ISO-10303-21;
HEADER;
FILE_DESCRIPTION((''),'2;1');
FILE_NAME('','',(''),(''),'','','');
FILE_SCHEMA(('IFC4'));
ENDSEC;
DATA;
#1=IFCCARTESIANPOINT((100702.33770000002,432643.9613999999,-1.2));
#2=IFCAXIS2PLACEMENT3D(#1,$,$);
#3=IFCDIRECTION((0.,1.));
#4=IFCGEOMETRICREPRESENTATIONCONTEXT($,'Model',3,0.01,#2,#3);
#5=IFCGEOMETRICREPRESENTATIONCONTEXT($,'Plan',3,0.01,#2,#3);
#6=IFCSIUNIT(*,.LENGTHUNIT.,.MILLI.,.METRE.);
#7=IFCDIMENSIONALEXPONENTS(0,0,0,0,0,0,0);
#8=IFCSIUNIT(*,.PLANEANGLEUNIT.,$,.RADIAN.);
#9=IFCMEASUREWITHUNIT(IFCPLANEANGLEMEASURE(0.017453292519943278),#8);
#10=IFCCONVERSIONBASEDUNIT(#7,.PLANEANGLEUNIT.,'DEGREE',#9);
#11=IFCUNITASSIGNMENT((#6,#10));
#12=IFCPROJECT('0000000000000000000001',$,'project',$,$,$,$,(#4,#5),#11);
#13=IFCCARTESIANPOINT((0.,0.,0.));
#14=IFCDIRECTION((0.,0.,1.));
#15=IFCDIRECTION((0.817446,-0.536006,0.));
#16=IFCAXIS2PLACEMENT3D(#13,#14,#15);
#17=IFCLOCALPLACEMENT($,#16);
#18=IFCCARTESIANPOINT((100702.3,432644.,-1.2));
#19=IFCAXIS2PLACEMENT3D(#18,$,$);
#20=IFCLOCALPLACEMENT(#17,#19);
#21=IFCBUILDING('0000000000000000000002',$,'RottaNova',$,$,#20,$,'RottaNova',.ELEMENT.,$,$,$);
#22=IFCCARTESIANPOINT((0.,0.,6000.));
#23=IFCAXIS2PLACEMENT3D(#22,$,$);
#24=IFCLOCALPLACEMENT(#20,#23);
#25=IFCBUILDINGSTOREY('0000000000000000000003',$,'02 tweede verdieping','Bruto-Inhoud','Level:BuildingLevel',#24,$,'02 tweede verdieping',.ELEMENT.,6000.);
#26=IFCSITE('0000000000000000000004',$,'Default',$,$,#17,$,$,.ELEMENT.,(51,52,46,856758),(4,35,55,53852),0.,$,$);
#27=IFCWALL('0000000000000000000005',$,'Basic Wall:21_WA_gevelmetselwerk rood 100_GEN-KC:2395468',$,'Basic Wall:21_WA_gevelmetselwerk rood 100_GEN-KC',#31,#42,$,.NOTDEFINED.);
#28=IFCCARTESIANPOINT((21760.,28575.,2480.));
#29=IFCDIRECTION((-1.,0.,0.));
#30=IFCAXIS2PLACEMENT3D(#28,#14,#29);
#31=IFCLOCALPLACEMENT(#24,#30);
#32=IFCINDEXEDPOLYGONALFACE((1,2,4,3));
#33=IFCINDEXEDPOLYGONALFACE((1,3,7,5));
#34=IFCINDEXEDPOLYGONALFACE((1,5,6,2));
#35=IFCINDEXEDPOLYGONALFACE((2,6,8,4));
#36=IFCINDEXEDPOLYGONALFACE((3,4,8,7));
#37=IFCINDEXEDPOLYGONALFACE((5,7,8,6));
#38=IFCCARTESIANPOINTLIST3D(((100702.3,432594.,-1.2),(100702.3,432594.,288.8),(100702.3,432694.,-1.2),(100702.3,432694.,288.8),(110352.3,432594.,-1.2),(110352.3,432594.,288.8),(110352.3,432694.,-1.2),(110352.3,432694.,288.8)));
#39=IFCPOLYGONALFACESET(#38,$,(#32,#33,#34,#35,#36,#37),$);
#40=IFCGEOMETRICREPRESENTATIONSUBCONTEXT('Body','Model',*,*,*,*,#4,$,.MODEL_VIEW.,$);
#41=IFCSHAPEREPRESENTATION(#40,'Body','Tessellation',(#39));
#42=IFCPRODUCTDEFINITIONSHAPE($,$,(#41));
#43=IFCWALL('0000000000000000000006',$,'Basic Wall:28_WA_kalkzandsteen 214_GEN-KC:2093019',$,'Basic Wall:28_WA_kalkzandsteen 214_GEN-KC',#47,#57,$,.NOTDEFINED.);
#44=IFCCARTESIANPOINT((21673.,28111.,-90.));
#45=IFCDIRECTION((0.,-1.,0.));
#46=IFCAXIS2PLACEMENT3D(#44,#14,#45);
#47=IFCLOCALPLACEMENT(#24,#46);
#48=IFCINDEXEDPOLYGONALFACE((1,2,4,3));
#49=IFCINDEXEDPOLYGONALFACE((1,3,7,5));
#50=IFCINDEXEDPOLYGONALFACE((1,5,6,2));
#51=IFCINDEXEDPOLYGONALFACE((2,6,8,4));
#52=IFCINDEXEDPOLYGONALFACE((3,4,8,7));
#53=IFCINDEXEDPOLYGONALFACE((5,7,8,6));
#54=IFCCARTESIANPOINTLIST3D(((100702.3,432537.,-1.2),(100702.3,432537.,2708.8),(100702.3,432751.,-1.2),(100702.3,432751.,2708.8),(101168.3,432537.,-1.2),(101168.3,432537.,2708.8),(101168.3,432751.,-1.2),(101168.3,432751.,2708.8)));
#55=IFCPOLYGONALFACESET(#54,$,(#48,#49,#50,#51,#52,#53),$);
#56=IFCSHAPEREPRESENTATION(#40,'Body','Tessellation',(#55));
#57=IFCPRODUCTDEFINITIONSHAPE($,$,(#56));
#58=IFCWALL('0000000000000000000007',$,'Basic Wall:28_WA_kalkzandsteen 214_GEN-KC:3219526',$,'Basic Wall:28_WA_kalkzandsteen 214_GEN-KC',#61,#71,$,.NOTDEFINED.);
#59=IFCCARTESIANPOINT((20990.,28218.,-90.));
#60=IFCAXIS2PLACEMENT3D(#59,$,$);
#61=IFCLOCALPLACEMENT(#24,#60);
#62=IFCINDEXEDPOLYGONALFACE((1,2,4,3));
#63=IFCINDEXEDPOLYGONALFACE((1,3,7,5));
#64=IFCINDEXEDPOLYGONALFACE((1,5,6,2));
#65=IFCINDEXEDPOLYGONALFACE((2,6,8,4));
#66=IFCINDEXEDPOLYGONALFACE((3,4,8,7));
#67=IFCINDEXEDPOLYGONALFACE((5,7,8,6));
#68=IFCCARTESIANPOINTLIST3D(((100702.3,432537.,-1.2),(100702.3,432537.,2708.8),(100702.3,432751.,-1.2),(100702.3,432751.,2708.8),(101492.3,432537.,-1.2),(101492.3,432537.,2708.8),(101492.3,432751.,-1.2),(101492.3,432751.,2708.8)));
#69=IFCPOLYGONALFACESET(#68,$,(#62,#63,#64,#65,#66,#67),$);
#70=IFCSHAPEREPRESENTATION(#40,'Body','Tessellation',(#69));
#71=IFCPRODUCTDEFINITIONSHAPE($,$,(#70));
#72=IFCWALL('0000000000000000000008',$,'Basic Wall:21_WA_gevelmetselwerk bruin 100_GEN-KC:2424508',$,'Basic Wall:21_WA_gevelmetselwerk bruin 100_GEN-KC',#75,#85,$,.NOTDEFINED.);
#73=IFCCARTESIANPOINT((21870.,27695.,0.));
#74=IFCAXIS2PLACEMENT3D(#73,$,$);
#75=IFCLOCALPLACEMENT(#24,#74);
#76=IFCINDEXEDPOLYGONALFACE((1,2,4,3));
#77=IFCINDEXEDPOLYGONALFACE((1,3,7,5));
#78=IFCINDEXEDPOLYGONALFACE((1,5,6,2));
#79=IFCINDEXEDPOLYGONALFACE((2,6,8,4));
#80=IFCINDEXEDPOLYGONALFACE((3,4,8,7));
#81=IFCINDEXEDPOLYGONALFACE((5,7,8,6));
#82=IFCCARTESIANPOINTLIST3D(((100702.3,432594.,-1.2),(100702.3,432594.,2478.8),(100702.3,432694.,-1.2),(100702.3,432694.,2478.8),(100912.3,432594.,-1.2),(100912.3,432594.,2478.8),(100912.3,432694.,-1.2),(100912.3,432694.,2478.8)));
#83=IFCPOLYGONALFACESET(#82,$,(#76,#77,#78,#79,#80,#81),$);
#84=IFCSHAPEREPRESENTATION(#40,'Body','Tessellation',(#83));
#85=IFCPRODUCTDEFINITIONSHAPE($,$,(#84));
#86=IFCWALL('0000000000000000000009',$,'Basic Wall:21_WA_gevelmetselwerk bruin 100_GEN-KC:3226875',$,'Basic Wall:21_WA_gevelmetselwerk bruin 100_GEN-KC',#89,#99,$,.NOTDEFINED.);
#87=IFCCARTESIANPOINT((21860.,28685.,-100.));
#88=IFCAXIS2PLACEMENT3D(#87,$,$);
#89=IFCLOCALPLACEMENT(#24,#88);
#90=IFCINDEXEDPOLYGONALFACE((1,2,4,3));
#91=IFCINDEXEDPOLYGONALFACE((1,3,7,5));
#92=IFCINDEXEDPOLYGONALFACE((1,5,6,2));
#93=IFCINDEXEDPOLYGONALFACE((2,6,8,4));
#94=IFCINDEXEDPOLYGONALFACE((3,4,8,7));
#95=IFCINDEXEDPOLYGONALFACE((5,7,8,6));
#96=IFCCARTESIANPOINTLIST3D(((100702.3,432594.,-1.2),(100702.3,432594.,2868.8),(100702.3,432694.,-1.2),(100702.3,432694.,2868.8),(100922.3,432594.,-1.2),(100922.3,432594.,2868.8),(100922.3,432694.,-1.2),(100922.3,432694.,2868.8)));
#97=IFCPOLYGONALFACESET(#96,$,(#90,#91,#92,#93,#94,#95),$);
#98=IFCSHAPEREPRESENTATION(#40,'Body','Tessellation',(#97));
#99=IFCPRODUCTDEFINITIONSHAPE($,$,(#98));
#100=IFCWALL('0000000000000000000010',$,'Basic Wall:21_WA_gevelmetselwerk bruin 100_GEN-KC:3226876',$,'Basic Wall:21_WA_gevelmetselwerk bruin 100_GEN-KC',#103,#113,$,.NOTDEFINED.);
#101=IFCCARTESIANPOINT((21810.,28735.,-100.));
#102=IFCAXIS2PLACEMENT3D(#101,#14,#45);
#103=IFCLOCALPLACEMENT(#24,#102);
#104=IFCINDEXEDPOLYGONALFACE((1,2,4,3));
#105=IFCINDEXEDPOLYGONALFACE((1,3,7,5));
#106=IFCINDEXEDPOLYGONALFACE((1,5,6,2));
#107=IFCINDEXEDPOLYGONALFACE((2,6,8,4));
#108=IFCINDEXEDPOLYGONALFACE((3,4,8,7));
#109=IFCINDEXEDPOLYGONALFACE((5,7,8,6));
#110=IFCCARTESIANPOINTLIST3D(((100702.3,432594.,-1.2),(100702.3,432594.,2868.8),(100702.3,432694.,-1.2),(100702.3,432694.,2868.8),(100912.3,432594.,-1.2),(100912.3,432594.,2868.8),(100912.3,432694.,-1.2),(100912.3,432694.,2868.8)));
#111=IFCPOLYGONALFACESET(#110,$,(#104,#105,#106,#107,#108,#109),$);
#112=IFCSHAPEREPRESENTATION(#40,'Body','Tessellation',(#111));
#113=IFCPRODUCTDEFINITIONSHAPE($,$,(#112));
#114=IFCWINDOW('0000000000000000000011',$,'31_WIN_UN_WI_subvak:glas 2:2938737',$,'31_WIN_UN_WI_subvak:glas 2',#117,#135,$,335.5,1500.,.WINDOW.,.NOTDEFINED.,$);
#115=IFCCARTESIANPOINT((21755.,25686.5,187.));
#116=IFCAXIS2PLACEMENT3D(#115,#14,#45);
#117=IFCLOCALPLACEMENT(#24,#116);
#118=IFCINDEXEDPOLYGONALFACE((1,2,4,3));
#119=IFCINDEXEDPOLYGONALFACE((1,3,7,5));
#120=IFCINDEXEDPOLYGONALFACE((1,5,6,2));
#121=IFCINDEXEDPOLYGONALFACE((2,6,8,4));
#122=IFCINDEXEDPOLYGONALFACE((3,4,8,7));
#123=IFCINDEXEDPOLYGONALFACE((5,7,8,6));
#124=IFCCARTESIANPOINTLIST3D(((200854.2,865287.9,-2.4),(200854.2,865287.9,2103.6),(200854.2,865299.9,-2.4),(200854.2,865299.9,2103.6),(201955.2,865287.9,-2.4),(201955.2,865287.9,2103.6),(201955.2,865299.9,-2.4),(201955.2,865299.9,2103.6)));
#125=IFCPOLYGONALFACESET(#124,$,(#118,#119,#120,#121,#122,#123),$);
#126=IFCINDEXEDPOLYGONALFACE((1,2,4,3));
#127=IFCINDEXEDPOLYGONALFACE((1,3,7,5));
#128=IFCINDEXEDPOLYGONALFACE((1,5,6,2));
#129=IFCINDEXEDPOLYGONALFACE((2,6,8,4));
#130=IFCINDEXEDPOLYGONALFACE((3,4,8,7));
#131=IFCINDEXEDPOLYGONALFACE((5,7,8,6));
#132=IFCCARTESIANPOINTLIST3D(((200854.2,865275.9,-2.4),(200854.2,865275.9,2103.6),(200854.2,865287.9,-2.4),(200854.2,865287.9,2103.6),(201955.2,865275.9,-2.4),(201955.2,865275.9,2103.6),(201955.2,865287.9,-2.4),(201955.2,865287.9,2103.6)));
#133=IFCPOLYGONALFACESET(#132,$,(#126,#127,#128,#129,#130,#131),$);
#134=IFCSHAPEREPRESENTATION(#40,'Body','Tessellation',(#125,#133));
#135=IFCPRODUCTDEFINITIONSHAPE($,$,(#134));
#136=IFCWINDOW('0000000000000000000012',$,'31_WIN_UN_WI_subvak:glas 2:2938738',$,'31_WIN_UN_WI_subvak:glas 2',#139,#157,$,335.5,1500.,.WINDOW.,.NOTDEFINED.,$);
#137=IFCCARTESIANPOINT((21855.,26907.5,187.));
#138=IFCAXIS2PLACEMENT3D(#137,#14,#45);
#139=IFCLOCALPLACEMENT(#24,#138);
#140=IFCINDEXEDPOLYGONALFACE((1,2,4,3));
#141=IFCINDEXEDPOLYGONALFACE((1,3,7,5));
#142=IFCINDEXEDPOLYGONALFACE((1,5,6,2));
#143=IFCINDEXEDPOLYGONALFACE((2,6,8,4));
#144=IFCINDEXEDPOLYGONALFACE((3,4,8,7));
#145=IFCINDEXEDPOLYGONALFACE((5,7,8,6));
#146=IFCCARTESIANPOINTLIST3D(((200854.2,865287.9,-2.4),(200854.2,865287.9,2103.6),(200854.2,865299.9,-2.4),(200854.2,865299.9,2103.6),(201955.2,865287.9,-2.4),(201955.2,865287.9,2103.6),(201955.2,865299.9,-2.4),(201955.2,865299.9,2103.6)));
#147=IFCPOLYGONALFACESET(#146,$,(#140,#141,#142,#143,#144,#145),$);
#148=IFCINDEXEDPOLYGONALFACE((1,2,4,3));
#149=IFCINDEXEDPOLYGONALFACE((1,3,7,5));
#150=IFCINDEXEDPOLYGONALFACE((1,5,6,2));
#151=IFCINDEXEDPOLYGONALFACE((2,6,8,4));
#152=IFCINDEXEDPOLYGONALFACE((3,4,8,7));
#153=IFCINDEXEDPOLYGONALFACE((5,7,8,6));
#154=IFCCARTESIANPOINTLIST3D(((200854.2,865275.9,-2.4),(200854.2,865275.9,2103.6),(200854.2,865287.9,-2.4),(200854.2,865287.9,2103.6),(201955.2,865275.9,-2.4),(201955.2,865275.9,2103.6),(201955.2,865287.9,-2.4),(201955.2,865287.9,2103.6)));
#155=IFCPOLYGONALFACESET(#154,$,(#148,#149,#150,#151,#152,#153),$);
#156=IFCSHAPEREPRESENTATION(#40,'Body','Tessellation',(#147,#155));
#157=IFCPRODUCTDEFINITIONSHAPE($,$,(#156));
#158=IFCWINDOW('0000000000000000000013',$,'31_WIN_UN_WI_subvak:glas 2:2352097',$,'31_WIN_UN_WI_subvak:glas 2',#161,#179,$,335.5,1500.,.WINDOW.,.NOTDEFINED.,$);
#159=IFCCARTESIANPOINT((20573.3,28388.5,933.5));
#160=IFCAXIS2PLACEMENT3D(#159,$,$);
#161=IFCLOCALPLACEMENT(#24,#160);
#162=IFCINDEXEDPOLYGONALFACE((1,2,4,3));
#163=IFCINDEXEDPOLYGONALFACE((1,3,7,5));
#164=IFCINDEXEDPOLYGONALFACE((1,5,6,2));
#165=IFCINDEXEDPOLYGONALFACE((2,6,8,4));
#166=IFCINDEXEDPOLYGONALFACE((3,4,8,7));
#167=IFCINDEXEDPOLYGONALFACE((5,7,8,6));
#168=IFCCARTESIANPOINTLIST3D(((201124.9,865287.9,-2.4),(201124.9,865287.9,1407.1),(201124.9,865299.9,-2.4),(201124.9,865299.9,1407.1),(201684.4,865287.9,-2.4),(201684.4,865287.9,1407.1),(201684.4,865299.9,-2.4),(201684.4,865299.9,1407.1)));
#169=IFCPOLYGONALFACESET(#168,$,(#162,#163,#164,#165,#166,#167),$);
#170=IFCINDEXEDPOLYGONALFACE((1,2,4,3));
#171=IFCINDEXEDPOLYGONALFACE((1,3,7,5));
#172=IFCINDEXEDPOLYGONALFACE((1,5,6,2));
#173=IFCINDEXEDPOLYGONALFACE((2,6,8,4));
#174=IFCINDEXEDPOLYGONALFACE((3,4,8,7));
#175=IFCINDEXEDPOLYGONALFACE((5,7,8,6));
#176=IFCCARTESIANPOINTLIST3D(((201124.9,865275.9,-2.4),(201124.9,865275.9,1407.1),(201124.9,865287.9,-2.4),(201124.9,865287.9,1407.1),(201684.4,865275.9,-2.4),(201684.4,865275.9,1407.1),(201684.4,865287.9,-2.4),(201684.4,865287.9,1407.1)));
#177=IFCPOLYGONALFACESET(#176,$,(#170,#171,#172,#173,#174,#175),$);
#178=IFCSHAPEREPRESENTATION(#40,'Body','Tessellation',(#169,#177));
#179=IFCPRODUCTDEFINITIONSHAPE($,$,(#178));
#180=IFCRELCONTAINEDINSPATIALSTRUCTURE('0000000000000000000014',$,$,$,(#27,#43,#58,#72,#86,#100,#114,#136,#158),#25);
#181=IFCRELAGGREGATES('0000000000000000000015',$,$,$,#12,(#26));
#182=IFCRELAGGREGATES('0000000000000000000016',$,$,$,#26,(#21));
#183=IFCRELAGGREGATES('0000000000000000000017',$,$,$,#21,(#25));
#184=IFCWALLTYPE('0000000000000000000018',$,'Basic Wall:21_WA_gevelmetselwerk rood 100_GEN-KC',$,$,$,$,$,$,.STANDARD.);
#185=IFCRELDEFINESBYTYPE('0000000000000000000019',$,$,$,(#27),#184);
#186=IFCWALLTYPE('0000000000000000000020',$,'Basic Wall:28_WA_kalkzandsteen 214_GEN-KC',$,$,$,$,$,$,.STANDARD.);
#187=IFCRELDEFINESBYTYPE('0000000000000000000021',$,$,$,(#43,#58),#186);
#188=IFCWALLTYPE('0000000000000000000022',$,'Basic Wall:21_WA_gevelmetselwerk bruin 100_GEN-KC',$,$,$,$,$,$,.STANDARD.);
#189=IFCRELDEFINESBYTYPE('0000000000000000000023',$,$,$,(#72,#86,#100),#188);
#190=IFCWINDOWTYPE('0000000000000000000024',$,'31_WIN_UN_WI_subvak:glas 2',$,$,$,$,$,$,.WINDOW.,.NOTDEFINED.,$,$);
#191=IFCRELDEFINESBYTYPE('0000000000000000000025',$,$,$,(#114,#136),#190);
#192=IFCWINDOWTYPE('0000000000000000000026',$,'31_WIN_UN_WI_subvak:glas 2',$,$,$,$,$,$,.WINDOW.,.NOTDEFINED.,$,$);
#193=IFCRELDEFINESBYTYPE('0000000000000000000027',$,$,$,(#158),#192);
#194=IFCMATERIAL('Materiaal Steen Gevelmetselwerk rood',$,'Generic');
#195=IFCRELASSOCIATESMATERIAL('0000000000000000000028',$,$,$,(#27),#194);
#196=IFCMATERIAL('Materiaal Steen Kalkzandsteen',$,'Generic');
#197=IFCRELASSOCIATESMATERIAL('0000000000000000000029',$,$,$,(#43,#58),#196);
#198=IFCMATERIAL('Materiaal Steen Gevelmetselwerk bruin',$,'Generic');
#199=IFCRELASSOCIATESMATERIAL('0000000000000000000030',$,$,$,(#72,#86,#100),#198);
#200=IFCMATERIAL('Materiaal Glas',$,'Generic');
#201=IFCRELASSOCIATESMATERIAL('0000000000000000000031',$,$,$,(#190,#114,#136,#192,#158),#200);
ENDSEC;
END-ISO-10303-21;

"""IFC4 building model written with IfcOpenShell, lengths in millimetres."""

from ifc_helpers import new_model, entity, si_unit, converted_unit, direction, frame, place, context, subcontext, project, spatial, indexed_curve, outline, extrude, source, transform, mapped, material, type_object, type_shapes, element, save


model = new_model("IFC4")

# Units and contexts
model_context = context("Model", 3, precision=0.01, world=frame((100702.33770000002, 432643.9613999999, -1.2)), true_north=direction((0.0, 1.0)))
plan_context = context("Plan", 3, precision=0.01, world=frame((100702.33770000002, 432643.9613999999, -1.2)), true_north=direction((0.0, 1.0)))
body_context = subcontext(model_context, "Body", "Model", "MODEL_VIEW")
ifc_project = project(units=[si_unit("LENGTHUNIT", "METRE", prefix="MILLI"), converted_unit("PLANEANGLEUNIT", "DEGREE", entity("IfcPlaneAngleMeasure", 0.017453292519943278), si_unit("PLANEANGLEUNIT", "RADIAN"), dimensions=[0, 0, 0, 0, 0, 0, 0])], contexts=[model_context, plan_context])

# Site, building, storey
site_placement = place(None, frame((0.0, 0.0, 0.0), z_axis=(0.0, 0.0, 1.0), x_axis=(0.817446, -0.536006, 0.0)))
site = spatial("IfcSite", under=ifc_project, at=site_placement, Name="Default", CompositionType="ELEMENT", RefLatitude=(51, 52, 46, 856758), RefLongitude=(4, 35, 55, 53852), RefElevation=0.0)
building_placement = place(site_placement, frame((100702.3, 432644.0, -1.2)))
building = spatial("IfcBuilding", under=site, at=building_placement, Name="RottaNova", LongName="RottaNova", CompositionType="ELEMENT")
storey_placement = place(building_placement, frame((0.0, 0.0, 6000.0)))
storey = spatial("IfcBuildingStorey", under=building, at=storey_placement, Name="02 tweede verdieping", Description="Bruto-Inhoud", ObjectType="Level:BuildingLevel", LongName="02 tweede verdieping", CompositionType="ELEMENT", Elevation=6000.0)

# Shared definitions
ifc_material_1 = material(Name="Materiaal Glas", Category="Generic")

# Walls
ifc_material_2 = material(Name="Materiaal Steen Gevelmetselwerk rood", Category="Generic")
wall_type_1 = type_object("IfcWallType", Name="Basic Wall:21_WA_gevelmetselwerk rood 100_GEN-KC", PredefinedType="STANDARD")
wall_1_placement = place(storey_placement, frame((21760.0, 28575.0, 2480.0), z_axis=(0.0, 0.0, 1.0), x_axis=(-1.0, 0.0, 0.0)))
element("IfcWall", 1, at=wall_1_placement, inside=storey, type_object=wall_type_1, material=ifc_material_2, Name="Basic Wall:21_WA_gevelmetselwerk rood 100_GEN-KC:2395468", ObjectType="Basic Wall:21_WA_gevelmetselwerk rood 100_GEN-KC", PredefinedType="NOTDEFINED", context=body_context, shape_type="SweptSolid", body=[
    extrude(outline(indexed_curve([(9650.0, 50.0), (0.0, 50.0), (0.0, -50.0), (9650.0, -50.0), (9650.0, 50.0)], self_intersect=False)), frame((100702.3, 432644.0, -1.2)), (0.0, 0.0, 1.0), 290.0),
])
ifc_material_3 = material(Name="Materiaal Steen Kalkzandsteen", Category="Generic")
wall_type_2 = type_object("IfcWallType", Name="Basic Wall:28_WA_kalkzandsteen 214_GEN-KC", PredefinedType="STANDARD")
wall_2_placement = place(storey_placement, frame((21673.0, 28111.0, -90.0), z_axis=(0.0, 0.0, 1.0), x_axis=(0.0, -1.0, 0.0)))
element("IfcWall", 2, at=wall_2_placement, inside=storey, type_object=wall_type_2, material=ifc_material_3, Name="Basic Wall:28_WA_kalkzandsteen 214_GEN-KC:2093019", ObjectType="Basic Wall:28_WA_kalkzandsteen 214_GEN-KC", PredefinedType="NOTDEFINED", context=body_context, shape_type="SweptSolid", body=[
    extrude(outline(indexed_curve([(466.0, 107.0), (0.0, 107.0), (0.0, -107.0), (466.0, -107.0), (466.0, 107.0)], self_intersect=False)), frame((100702.3, 432644.0, -1.2)), (0.0, 0.0, 1.0), 2710.0),
])
wall_3_placement = place(storey_placement, frame((20990.0, 28218.0, -90.0)))
element("IfcWall", 3, at=wall_3_placement, inside=storey, type_object=wall_type_2, material=ifc_material_3, Name="Basic Wall:28_WA_kalkzandsteen 214_GEN-KC:3219526", ObjectType="Basic Wall:28_WA_kalkzandsteen 214_GEN-KC", PredefinedType="NOTDEFINED", context=body_context, shape_type="SweptSolid", body=[
    extrude(outline(indexed_curve([(790.0, 107.0), (0.0, 107.0), (0.0, -107.0), (790.0, -107.0), (790.0, 107.0)], self_intersect=False)), frame((100702.3, 432644.0, -1.2)), (0.0, 0.0, 1.0), 2710.0),
])
ifc_material_4 = material(Name="Materiaal Steen Gevelmetselwerk bruin", Category="Generic")
wall_type_3 = type_object("IfcWallType", Name="Basic Wall:21_WA_gevelmetselwerk bruin 100_GEN-KC", PredefinedType="STANDARD")
wall_4_placement = place(storey_placement, frame((21870.0, 27695.0, 0.0)))
element("IfcWall", 4, at=wall_4_placement, inside=storey, type_object=wall_type_3, material=ifc_material_4, Name="Basic Wall:21_WA_gevelmetselwerk bruin 100_GEN-KC:2424508", ObjectType="Basic Wall:21_WA_gevelmetselwerk bruin 100_GEN-KC", PredefinedType="NOTDEFINED", context=body_context, shape_type="SweptSolid", body=[
    extrude(outline(indexed_curve([(210.0, 50.0), (0.0, 50.0), (0.0, -50.0), (210.0, -50.0), (210.0, 50.0)], self_intersect=False)), frame((100702.3, 432644.0, -1.2)), (0.0, 0.0, 1.0), 2480.0),
])
wall_5_placement = place(storey_placement, frame((21860.0, 28685.0, -100.0)))
element("IfcWall", 5, at=wall_5_placement, inside=storey, type_object=wall_type_3, material=ifc_material_4, Name="Basic Wall:21_WA_gevelmetselwerk bruin 100_GEN-KC:3226875", ObjectType="Basic Wall:21_WA_gevelmetselwerk bruin 100_GEN-KC", PredefinedType="NOTDEFINED", context=body_context, shape_type="SweptSolid", body=[
    extrude(outline(indexed_curve([(220.0, 50.0), (0.0, 50.0), (0.0, -50.0), (220.0, -50.0), (220.0, 50.0)], self_intersect=False)), frame((100702.3, 432644.0, -1.2)), (0.0, 0.0, 1.0), 2870.0),
])
wall_6_placement = place(storey_placement, frame((21810.0, 28735.0, -100.0), z_axis=(0.0, 0.0, 1.0), x_axis=(0.0, -1.0, 0.0)))
element("IfcWall", 6, at=wall_6_placement, inside=storey, type_object=wall_type_3, material=ifc_material_4, Name="Basic Wall:21_WA_gevelmetselwerk bruin 100_GEN-KC:3226876", ObjectType="Basic Wall:21_WA_gevelmetselwerk bruin 100_GEN-KC", PredefinedType="NOTDEFINED", context=body_context, shape_type="SweptSolid", body=[
    extrude(outline(indexed_curve([(210.0, 50.0), (0.0, 50.0), (0.0, -50.0), (210.0, -50.0), (210.0, 50.0)], self_intersect=False)), frame((100702.3, 432644.0, -1.2)), (0.0, 0.0, 1.0), 2870.0),
])

# Windows
window_type_1 = type_object("IfcWindowType", Name="31_WIN_UN_WI_subvak:glas 2", PartitioningType="NOTDEFINED", PredefinedType="WINDOW", material=ifc_material_1)
shared_shape_1 = source(frame((100702.3, 432644.0, -1.2)), body_context, "Body", "SweptSolid", [
    extrude(outline(indexed_curve([(-6.0, -550.5), (6.0, -550.5), (6.0, 550.5), (-6.0, 550.5), (-6.0, -550.5)], self_intersect=False)), frame((0.0, 6.0, 0.0), z_axis=(0.0, 0.0, 1.0), x_axis=(0.0, -1.0, 0.0)), (0.0, 0.0, 1.0), 2106.0),
    extrude(outline(indexed_curve([(-6.0, -550.5), (6.0, -550.5), (6.0, 550.5), (-6.0, 550.5), (-6.0, -550.5)], self_intersect=False)), frame((0.0, -6.0, 0.0), z_axis=(0.0, 0.0, 1.0), x_axis=(0.0, -1.0, 0.0)), (0.0, 0.0, 1.0), 2106.0),
])
type_shapes(window_type_1, [shared_shape_1])
for number, where, z_axis, x_axis, name in (
    (7, (21755.0, 25686.5, 187.0), (0.0, 0.0, 1.0), (0.0, -1.0, 0.0), "31_WIN_UN_WI_subvak:glas 2:2938737"),
    (8, (21855.0, 26907.5, 187.0), (0.0, 0.0, 1.0), (0.0, -1.0, 0.0), "31_WIN_UN_WI_subvak:glas 2:2938738"),
):
    element("IfcWindow", number, at=place(storey_placement, frame(where, z_axis=z_axis, x_axis=x_axis)), inside=storey, type_object=window_type_1, material=ifc_material_1, Name=name, ObjectType="31_WIN_UN_WI_subvak:glas 2", OverallHeight=335.5, OverallWidth=1500.0, PartitioningType="NOTDEFINED", PredefinedType="WINDOW", context=body_context, shape_type="MappedRepresentation", body=[
        mapped(shared_shape_1, transform((100702.3, 432644.0, -1.2), scale=1.0)),
    ])
window_type_2 = type_object("IfcWindowType", Name="31_WIN_UN_WI_subvak:glas 2", PartitioningType="NOTDEFINED", PredefinedType="WINDOW", material=ifc_material_1)
shared_shape_2 = source(frame((100702.3, 432644.0, -1.2)), body_context, "Body", "SweptSolid", [
    extrude(outline(indexed_curve([(-6.0, -279.8), (6.0, -279.8), (6.0, 279.8), (-6.0, 279.8), (-6.0, -279.8)], self_intersect=False)), frame((0.0, 6.0, 0.0), z_axis=(0.0, 0.0, 1.0), x_axis=(0.0, -1.0, 0.0)), (0.0, 0.0, 1.0), 1409.5),
    extrude(outline(indexed_curve([(-6.0, -279.8), (6.0, -279.8), (6.0, 279.8), (-6.0, 279.8), (-6.0, -279.8)], self_intersect=False)), frame((0.0, -6.0, 0.0), z_axis=(0.0, 0.0, 1.0), x_axis=(0.0, -1.0, 0.0)), (0.0, 0.0, 1.0), 1409.5),
])
type_shapes(window_type_2, [shared_shape_2])
window_1_placement = place(storey_placement, frame((20573.3, 28388.5, 933.5)))
element("IfcWindow", 9, at=window_1_placement, inside=storey, type_object=window_type_2, material=ifc_material_1, Name="31_WIN_UN_WI_subvak:glas 2:2352097", ObjectType="31_WIN_UN_WI_subvak:glas 2", OverallHeight=335.5, OverallWidth=1500.0, PartitioningType="NOTDEFINED", PredefinedType="WINDOW", context=body_context, shape_type="MappedRepresentation", body=[
    mapped(shared_shape_2, transform((100702.3, 432644.0, -1.2), scale=1.0)),
])

save(model, "model.ifc")
